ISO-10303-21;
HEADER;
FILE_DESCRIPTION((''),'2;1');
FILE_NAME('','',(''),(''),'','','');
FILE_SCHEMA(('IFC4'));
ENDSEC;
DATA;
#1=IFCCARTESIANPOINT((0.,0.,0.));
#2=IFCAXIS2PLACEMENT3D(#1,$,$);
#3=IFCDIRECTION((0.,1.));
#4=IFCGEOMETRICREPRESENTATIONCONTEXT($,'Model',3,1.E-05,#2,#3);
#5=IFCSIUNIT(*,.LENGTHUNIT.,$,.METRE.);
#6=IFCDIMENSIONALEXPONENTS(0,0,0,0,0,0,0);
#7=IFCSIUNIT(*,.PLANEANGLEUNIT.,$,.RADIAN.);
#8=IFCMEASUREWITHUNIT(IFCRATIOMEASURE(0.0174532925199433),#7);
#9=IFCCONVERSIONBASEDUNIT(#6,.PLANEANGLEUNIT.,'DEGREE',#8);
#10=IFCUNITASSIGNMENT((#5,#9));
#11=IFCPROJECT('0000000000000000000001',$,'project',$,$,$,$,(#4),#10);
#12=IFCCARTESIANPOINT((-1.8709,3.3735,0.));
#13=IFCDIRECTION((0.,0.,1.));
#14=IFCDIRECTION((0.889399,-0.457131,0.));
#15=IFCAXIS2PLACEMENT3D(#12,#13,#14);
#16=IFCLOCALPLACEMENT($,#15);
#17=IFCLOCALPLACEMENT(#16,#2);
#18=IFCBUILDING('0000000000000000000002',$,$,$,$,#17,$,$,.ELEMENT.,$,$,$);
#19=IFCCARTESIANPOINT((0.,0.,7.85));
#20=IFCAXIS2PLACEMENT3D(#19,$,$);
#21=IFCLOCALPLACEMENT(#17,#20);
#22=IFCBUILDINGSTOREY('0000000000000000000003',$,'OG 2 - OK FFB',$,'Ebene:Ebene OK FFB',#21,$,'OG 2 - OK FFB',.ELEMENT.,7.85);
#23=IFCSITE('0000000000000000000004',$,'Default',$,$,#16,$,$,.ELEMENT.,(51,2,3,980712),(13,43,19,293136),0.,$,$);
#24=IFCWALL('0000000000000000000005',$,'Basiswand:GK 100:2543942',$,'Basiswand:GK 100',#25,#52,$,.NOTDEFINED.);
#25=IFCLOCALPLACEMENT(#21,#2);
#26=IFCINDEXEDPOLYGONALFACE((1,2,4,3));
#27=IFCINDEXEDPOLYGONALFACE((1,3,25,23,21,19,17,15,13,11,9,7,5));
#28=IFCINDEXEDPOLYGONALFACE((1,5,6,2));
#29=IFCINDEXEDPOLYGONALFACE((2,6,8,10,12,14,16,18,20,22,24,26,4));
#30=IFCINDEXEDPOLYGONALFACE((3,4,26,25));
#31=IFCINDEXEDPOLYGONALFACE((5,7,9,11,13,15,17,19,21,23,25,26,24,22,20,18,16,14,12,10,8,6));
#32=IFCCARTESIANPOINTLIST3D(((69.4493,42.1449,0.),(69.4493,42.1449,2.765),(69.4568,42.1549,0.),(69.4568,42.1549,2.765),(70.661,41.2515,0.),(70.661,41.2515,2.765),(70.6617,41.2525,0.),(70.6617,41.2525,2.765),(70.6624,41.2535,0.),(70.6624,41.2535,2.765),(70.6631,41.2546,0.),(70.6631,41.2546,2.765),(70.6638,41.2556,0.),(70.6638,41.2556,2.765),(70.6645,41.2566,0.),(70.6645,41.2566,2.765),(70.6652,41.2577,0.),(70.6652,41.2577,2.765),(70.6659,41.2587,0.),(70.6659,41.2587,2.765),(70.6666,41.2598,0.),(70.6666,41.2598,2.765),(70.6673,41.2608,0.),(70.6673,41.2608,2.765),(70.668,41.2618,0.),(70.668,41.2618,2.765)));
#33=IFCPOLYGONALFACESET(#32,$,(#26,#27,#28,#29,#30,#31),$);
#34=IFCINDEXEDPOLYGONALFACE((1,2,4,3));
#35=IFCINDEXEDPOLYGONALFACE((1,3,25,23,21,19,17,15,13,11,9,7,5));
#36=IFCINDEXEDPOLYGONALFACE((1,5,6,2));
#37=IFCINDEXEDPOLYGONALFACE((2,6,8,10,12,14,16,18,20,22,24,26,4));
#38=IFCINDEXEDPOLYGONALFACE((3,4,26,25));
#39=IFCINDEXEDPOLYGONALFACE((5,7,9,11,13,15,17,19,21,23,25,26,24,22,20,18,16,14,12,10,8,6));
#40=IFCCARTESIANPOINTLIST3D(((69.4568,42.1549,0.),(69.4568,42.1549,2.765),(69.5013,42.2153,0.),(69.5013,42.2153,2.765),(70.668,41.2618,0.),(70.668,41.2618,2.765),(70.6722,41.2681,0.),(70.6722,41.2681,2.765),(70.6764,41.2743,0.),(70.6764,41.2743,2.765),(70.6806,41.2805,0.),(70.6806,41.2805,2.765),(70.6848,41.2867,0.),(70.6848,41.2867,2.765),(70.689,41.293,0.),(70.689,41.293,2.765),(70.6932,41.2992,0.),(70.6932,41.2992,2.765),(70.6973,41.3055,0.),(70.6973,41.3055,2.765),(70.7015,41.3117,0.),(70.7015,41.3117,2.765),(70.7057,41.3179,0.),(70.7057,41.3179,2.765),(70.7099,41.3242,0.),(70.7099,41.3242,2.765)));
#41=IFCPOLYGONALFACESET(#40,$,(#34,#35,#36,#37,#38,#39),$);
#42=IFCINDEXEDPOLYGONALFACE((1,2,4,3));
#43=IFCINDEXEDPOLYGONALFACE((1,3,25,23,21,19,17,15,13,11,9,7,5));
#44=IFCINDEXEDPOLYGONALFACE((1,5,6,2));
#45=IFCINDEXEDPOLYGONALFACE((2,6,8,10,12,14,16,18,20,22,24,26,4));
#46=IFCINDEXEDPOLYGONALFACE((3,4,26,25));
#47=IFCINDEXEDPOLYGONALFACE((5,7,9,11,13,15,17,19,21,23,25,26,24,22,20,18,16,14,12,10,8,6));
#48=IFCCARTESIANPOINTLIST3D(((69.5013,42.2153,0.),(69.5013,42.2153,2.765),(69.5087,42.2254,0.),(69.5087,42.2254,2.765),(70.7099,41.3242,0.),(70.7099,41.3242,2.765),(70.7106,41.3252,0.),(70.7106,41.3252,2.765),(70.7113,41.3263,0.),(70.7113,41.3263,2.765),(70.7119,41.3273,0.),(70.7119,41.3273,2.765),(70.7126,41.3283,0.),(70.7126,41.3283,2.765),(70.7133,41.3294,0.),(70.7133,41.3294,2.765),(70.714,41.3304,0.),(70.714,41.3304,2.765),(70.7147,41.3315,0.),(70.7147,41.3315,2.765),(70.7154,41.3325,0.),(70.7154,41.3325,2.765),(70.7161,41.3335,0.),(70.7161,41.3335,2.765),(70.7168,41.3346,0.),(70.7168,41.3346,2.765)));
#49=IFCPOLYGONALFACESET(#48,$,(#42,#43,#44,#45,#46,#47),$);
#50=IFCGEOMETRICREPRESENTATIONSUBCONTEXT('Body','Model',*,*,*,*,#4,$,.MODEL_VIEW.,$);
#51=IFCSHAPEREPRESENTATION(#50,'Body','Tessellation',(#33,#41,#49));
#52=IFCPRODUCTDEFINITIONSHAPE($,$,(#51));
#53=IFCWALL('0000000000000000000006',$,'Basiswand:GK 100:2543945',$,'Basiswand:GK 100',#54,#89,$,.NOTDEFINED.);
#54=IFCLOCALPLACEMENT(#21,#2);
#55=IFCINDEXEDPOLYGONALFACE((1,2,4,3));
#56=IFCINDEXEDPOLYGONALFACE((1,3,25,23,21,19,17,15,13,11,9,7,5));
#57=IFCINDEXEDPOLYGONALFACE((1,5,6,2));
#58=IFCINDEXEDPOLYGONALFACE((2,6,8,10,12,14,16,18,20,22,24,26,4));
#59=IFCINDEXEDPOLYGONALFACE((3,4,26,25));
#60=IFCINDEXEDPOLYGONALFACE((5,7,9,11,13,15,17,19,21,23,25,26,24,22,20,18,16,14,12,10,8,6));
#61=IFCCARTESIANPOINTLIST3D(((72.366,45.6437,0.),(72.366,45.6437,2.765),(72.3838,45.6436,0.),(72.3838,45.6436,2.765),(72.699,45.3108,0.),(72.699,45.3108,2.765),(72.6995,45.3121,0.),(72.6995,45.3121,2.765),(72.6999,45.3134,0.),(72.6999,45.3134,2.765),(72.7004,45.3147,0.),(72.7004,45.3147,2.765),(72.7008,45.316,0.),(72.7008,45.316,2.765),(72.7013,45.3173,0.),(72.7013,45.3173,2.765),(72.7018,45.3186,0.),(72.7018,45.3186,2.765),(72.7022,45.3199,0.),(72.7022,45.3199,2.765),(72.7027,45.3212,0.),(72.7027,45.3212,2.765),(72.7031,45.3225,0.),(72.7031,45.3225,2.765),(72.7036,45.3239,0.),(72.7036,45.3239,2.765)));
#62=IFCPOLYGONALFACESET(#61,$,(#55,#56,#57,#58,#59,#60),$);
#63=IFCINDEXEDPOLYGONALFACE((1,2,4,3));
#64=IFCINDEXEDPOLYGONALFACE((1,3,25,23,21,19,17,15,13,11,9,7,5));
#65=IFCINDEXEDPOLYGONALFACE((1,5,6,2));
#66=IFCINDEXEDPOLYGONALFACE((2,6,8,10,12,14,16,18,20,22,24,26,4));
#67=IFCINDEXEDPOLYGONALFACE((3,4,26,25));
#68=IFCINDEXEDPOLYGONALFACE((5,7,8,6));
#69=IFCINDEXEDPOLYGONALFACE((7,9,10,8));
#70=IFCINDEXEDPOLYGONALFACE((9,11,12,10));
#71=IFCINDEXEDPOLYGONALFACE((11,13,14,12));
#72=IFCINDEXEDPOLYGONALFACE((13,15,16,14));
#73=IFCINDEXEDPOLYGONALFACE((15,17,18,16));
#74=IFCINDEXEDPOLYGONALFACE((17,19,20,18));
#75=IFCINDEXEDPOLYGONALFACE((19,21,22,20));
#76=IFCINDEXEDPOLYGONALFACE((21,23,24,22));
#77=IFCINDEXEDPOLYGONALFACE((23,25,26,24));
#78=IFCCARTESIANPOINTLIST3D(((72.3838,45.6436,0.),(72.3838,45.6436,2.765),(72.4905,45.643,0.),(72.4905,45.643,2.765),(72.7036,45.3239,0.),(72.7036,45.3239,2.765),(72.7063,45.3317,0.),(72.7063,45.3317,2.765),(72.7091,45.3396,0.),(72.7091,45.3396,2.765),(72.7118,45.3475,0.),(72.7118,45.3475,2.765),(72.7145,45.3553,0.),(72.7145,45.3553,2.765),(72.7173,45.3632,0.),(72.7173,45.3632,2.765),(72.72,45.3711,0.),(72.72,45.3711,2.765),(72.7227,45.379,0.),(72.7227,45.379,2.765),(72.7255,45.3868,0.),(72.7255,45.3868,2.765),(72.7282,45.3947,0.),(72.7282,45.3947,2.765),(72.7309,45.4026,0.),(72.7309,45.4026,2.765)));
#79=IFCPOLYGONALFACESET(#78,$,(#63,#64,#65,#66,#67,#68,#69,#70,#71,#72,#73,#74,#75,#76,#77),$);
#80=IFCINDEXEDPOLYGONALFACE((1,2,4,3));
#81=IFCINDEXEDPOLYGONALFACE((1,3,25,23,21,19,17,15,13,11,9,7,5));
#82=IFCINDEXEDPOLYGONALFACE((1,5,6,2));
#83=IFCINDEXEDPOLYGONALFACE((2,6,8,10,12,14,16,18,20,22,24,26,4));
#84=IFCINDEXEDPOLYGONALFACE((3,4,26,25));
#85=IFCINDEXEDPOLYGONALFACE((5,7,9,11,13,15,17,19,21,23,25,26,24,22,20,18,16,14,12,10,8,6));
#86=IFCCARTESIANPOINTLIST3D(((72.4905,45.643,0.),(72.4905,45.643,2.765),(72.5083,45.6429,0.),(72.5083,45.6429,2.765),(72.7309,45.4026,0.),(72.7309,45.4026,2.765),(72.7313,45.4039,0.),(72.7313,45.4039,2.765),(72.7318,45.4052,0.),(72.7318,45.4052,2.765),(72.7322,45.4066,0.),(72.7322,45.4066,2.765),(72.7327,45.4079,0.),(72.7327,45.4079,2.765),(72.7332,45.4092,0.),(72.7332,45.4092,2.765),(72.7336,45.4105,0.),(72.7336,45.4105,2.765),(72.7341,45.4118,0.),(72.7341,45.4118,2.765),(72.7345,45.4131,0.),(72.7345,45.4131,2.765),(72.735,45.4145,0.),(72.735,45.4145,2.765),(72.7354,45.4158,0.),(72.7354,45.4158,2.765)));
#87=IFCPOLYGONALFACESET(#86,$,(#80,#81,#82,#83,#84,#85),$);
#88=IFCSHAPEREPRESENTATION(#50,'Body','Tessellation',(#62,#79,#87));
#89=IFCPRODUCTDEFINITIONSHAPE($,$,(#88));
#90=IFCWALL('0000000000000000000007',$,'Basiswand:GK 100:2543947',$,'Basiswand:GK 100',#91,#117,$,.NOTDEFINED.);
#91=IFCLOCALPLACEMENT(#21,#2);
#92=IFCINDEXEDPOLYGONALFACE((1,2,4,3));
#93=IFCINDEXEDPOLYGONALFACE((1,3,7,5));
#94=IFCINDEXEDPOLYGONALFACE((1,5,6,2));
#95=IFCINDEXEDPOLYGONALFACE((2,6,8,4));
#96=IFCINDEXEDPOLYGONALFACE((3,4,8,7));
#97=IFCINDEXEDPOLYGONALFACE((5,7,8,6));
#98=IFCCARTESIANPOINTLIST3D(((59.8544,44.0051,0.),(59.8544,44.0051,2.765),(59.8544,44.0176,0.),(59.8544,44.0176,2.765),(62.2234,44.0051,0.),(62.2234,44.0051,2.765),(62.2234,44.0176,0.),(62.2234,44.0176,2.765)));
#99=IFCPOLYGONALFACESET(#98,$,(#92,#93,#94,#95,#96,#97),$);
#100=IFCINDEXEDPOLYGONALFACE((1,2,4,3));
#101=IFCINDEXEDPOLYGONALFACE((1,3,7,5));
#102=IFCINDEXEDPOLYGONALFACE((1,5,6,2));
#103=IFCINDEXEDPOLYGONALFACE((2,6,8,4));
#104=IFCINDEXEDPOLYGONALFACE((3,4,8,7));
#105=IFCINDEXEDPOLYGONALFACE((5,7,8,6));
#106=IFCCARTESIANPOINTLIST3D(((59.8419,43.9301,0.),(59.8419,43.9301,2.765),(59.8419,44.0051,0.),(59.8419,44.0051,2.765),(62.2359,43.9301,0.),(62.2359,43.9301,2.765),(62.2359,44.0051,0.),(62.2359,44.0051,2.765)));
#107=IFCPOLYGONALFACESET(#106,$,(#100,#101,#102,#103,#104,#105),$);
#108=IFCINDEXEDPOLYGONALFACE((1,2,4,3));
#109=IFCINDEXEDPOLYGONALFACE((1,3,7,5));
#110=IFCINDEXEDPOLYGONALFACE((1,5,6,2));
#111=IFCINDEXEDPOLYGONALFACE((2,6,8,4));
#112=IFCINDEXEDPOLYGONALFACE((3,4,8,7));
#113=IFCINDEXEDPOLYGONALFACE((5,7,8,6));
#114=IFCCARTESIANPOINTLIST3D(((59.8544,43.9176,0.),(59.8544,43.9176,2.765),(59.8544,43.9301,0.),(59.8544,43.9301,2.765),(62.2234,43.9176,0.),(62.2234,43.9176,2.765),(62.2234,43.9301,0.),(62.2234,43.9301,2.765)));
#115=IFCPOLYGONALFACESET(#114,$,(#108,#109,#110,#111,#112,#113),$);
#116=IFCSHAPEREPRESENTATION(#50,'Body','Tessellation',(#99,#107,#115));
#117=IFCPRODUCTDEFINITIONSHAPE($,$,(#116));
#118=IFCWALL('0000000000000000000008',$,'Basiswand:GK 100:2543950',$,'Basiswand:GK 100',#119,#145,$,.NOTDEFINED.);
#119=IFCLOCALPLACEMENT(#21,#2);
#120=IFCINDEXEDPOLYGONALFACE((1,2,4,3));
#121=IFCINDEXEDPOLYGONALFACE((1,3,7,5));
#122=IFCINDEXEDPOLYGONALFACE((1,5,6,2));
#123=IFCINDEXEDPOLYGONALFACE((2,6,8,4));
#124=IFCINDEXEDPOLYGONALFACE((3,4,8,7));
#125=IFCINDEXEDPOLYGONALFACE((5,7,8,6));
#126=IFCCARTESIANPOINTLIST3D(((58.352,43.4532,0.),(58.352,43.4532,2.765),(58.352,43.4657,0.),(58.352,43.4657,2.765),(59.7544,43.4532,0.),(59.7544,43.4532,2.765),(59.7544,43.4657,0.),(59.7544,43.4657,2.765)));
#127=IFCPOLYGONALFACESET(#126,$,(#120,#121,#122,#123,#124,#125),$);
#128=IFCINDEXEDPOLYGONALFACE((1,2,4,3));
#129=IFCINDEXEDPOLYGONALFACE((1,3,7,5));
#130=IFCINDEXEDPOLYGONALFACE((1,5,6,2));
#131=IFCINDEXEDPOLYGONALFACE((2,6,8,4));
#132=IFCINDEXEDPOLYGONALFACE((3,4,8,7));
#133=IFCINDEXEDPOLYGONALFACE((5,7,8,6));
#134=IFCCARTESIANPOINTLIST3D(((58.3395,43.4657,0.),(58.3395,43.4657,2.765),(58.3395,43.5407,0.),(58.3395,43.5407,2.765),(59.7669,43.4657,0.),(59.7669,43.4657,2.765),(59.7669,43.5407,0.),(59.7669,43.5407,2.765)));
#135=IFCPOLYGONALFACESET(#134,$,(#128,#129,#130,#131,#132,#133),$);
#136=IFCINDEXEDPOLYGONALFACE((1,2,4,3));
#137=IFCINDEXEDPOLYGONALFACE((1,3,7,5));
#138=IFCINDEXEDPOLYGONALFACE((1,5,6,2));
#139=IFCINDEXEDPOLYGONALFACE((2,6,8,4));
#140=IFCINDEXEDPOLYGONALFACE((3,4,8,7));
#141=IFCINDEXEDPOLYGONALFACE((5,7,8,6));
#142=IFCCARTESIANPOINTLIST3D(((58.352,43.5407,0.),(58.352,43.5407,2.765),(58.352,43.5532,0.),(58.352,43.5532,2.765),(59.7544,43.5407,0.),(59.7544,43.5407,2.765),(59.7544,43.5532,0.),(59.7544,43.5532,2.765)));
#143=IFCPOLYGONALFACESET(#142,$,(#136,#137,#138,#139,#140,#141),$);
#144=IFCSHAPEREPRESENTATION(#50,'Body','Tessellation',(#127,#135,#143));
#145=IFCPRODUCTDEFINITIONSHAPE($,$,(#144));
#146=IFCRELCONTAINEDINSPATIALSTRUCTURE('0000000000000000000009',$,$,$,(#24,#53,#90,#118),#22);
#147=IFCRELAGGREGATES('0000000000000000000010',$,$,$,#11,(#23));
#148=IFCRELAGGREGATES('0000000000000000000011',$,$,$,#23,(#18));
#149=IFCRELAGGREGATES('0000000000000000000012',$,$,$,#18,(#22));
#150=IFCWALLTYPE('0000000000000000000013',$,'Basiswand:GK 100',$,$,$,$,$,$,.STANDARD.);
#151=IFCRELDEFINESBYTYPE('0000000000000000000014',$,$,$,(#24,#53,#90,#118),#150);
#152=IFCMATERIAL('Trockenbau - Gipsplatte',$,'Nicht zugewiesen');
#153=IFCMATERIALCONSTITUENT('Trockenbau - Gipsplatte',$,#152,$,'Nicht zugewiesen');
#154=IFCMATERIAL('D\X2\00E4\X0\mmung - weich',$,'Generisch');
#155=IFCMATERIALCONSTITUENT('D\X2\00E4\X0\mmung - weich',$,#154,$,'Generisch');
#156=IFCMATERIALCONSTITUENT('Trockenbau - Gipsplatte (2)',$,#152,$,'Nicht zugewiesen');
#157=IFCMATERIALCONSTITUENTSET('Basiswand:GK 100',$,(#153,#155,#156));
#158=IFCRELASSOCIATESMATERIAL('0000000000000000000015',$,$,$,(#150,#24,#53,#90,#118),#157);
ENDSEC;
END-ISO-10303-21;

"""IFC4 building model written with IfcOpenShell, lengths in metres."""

from ifc_helpers import new_model, entity, si_unit, converted_unit, direction, frame, origin, place, context, subcontext, project, spatial, indexed_curve, outline, extrude, material, constituent, constituent_set, type_object, element, save


model = new_model("IFC4")

# Units and contexts
model_context = context("Model", 3, precision=1e-05, world=origin(), true_north=direction((0.0, 1.0)))
body_context = subcontext(model_context, "Body", "Model", "MODEL_VIEW")
ifc_project = project(units=[si_unit("LENGTHUNIT", "METRE"), converted_unit("PLANEANGLEUNIT", "DEGREE", entity("IfcRatioMeasure", 0.0174532925199433), si_unit("PLANEANGLEUNIT", "RADIAN"), dimensions=[0, 0, 0, 0, 0, 0, 0])], contexts=[model_context])

# Site, building, storey
site_placement = place(None, frame((-1.8709, 3.3735, 0.0), z_axis=(0.0, 0.0, 1.0), x_axis=(0.889399, -0.457131, 0.0)))
site = spatial("IfcSite", under=ifc_project, at=site_placement, Name="Default", CompositionType="ELEMENT", RefLatitude=(51, 2, 3, 980712), RefLongitude=(13, 43, 19, 293136), RefElevation=0.0)
building_placement = place(site_placement, origin())
building = spatial("IfcBuilding", under=site, at=building_placement, CompositionType="ELEMENT")
storey_placement = place(building_placement, frame((0.0, 0.0, 7.85)))
storey = spatial("IfcBuildingStorey", under=building, at=storey_placement, Name="OG 2 - OK FFB", ObjectType="Ebene:Ebene OK FFB", LongName="OG 2 - OK FFB", CompositionType="ELEMENT", Elevation=7.85)

# Shared definitions
ifc_material_1 = material(Name="Trockenbau - Gipsplatte", Category="Nicht zugewiesen")
ifc_constituent_1 = constituent(ifc_material_1, Name="Trockenbau - Gipsplatte", Category="Nicht zugewiesen")
ifc_material_2 = material(Name="Dämmung - weich", Category="Generisch")
ifc_constituent_2 = constituent(ifc_material_2, Name="Dämmung - weich", Category="Generisch")
ifc_constituent_3 = constituent(ifc_material_1, Name="Trockenbau - Gipsplatte (2)", Category="Nicht zugewiesen")
ifc_constituent_set_1 = constituent_set(constituents=[ifc_constituent_1, ifc_constituent_2, ifc_constituent_3], Name="Basiswand:GK 100")
wall_type_1 = type_object("IfcWallType", Name="Basiswand:GK 100", PredefinedType="STANDARD", material=ifc_constituent_set_1)

# Walls
wall_1_placement = place(storey_placement, frame((69.479, 42.1851, 0.0), z_axis=(0.0, 0.0, 1.0), x_axis=(0.80487, -0.593452, 0.0)))
element("IfcWall", 1, at=wall_1_placement, inside=storey, type_object=wall_type_1, material=ifc_constituent_set_1, Name="Basiswand:GK 100:2543942", ObjectType="Basiswand:GK 100", PredefinedType="NOTDEFINED", context=body_context, shape_type="SweptSolid", body=[
    extrude(outline(indexed_curve([(-0.0379, -0.7519), (-0.0366, -0.7519), (-0.0354, -0.7519), (-0.0341, -0.7519), (-0.0329, -0.7519), (-0.0316, -0.7519), (-0.0304, -0.7519), (-0.0291, -0.7519), (-0.0279, -0.7519), (-0.0266, -0.7519), (-0.0254, -0.7519), (0.0379, 0.7517), (0.0254, 0.7522), (-0.0379, -0.7519)], self_intersect=False)), frame((0.7526, -0.0438, 0.0), z_axis=(0.0, 0.0, 1.0), x_axis=(-0.041997, 0.999118, 0.0)), (0.0, 0.0, 1.0), 2.765),
    extrude(outline(indexed_curve([(-0.7516, -0.0375), (0.7533, -0.0375), (0.753, -0.03), (0.7527, -0.0225), (0.7523, -0.015), (0.752, -0.0075), (0.7517, 0.0), (0.7513, 0.0075), (0.751, 0.015), (0.7507, 0.0225), (0.7503, 0.03), (0.75, 0.0375), (-0.7516, 0.0375), (-0.7516, -0.0375)], self_intersect=False)), frame((0.7516, 0.0, 0.0)), (0.0, 0.0, 1.0), 2.765),
    extrude(outline(indexed_curve([(-0.0062, -0.7507), (0.0063, -0.7507), (0.0062, 0.7509), (0.005, 0.7509), (0.0037, 0.7508), (0.0025, 0.7508), (0.0012, 0.7507), (0.0, 0.7507), (-0.0013, 0.7506), (-0.0025, 0.7505), (-0.0038, 0.7505), (-0.005, 0.7504), (-0.0062, 0.7504), (-0.0062, -0.7507)], self_intersect=False)), frame((0.7507, 0.0437, 0.0), z_axis=(0.0, 0.0, 1.0), x_axis=(0.0, -1.0, 0.0)), (0.0, 0.0, 1.0), 2.765),
])
wall_2_placement = place(storey_placement, frame((72.4014, 45.6791, 0.0), z_axis=(0.0, 0.0, 1.0), x_axis=(0.707107, -0.707107, 0.0)))
element("IfcWall", 2, at=wall_2_placement, inside=storey, type_object=wall_type_1, material=ifc_constituent_set_1, Name="Basiswand:GK 100:2543945", ObjectType="Basiswand:GK 100", PredefinedType="NOTDEFINED", context=body_context, shape_type="SweptSolid", body=[
    extrude(outline(indexed_curve([(-0.1071, -0.2079), (-0.1057, -0.2079), (-0.1043, -0.2079), (-0.1029, -0.2079), (-0.1015, -0.2079), (-0.1002, -0.2079), (-0.0988, -0.2079), (-0.0974, -0.2079), (-0.096, -0.2079), (-0.0946, -0.2079), (-0.0932, -0.2079), (0.103, 0.1995), (0.0973, 0.2163), (-0.1071, -0.2079)], self_intersect=False)), frame((0.2371, -0.0438, 0.0), z_axis=(0.0, 0.0, 1.0), x_axis=(-0.43398, 0.900922, 0.0)), (0.0, 0.0, 1.0), 2.765),
    extrude(outline(indexed_curve([(-0.236, -0.0375), (0.2162, -0.0375), (0.2126, -0.03), (0.209, -0.0225), (0.2054, -0.015), (0.2017, -0.0075), (0.1981, 0.0), (0.1945, 0.0075), (0.1908, 0.015), (0.1872, 0.0225), (0.1835, 0.03), (0.1799, 0.0375), (-0.1601, 0.0375), (-0.236, -0.0375)], self_intersect=False)), frame((0.2487, 0.0, 0.0)), (0.0, 0.0, 1.0), 2.765),
    extrude(outline(indexed_curve([(0.1087, -0.1162), (0.1265, -0.1162), (-0.1154, 0.1228), (-0.1158, 0.1214), (-0.1162, 0.1201), (-0.1167, 0.1188), (-0.1171, 0.1175), (-0.1176, 0.1162), (-0.118, 0.1149), (-0.1185, 0.1135), (-0.1189, 0.1122), (-0.1194, 0.1109), (-0.1198, 0.1096), (0.1087, -0.1162)], self_intersect=False)), frame((0.2602, 0.0437, 0.0), z_axis=(0.0, 0.0, 1.0), x_axis=(-0.711343, -0.702845, 0.0)), (0.0, 0.0, 1.0), 2.765),
])
wall_3_placement = place(storey_placement, frame((62.2234, 43.9676, 0.0), z_axis=(0.0, 0.0, 1.0), x_axis=(-1.0, 0.0, 0.0)))
element("IfcWall", 3, at=wall_3_placement, inside=storey, type_object=wall_type_1, material=ifc_constituent_set_1, Name="Basiswand:GK 100:2543947", ObjectType="Basiswand:GK 100", PredefinedType="NOTDEFINED", context=body_context, shape_type="SweptSolid", body=[
    extrude(outline(indexed_curve([(-0.0063, -1.1845), (0.0063, -1.1845), (0.0063, 1.1845), (-0.0062, 1.1845), (-0.0063, -1.1845)], self_intersect=False)), frame((1.1845, -0.0438, 0.0), z_axis=(0.0, 0.0, 1.0), x_axis=(0.0, 1.0, 0.0)), (0.0, 0.0, 1.0), 2.765),
    extrude(outline(indexed_curve([(-1.197, -0.0375), (1.197, -0.0375), (1.197, 0.0375), (-1.197, 0.0375), (-1.197, -0.0375)], self_intersect=False)), frame((1.1845, 0.0, 0.0)), (0.0, 0.0, 1.0), 2.765),
    extrude(outline(indexed_curve([(-0.0063, -1.1845), (0.0062, -1.1845), (0.0063, 1.1845), (-0.0062, 1.1845), (-0.0063, -1.1845)], self_intersect=False)), frame((1.1845, 0.0437, 0.0), z_axis=(0.0, 0.0, 1.0), x_axis=(0.0, -1.0, 0.0)), (0.0, 0.0, 1.0), 2.765),
])
wall_4_placement = place(storey_placement, frame((58.352, 43.5032, 0.0)))
element("IfcWall", 4, at=wall_4_placement, inside=storey, type_object=wall_type_1, material=ifc_constituent_set_1, Name="Basiswand:GK 100:2543950", ObjectType="Basiswand:GK 100", PredefinedType="NOTDEFINED", context=body_context, shape_type="SweptSolid", body=[
    extrude(outline(indexed_curve([(-0.0063, -0.7012), (0.0062, -0.7012), (0.0063, 0.7012), (-0.0063, 0.7012), (-0.0063, -0.7012)], self_intersect=False)), frame((0.7012, -0.0438, 0.0), z_axis=(0.0, 0.0, 1.0), x_axis=(0.0, 1.0, 0.0)), (0.0, 0.0, 1.0), 2.765),
    extrude(outline(indexed_curve([(-0.7137, -0.0375), (0.7137, -0.0375), (0.7137, 0.0375), (-0.7137, 0.0375), (-0.7137, -0.0375)], self_intersect=False)), frame((0.7012, 0.0, 0.0)), (0.0, 0.0, 1.0), 2.765),
    extrude(outline(indexed_curve([(-0.0062, -0.7012), (0.0063, -0.7012), (0.0062, 0.7012), (-0.0063, 0.7012), (-0.0062, -0.7012)], self_intersect=False)), frame((0.7012, 0.0437, 0.0), z_axis=(0.0, 0.0, 1.0), x_axis=(0.0, -1.0, 0.0)), (0.0, 0.0, 1.0), 2.765),
])

save(model, "model.ifc")
